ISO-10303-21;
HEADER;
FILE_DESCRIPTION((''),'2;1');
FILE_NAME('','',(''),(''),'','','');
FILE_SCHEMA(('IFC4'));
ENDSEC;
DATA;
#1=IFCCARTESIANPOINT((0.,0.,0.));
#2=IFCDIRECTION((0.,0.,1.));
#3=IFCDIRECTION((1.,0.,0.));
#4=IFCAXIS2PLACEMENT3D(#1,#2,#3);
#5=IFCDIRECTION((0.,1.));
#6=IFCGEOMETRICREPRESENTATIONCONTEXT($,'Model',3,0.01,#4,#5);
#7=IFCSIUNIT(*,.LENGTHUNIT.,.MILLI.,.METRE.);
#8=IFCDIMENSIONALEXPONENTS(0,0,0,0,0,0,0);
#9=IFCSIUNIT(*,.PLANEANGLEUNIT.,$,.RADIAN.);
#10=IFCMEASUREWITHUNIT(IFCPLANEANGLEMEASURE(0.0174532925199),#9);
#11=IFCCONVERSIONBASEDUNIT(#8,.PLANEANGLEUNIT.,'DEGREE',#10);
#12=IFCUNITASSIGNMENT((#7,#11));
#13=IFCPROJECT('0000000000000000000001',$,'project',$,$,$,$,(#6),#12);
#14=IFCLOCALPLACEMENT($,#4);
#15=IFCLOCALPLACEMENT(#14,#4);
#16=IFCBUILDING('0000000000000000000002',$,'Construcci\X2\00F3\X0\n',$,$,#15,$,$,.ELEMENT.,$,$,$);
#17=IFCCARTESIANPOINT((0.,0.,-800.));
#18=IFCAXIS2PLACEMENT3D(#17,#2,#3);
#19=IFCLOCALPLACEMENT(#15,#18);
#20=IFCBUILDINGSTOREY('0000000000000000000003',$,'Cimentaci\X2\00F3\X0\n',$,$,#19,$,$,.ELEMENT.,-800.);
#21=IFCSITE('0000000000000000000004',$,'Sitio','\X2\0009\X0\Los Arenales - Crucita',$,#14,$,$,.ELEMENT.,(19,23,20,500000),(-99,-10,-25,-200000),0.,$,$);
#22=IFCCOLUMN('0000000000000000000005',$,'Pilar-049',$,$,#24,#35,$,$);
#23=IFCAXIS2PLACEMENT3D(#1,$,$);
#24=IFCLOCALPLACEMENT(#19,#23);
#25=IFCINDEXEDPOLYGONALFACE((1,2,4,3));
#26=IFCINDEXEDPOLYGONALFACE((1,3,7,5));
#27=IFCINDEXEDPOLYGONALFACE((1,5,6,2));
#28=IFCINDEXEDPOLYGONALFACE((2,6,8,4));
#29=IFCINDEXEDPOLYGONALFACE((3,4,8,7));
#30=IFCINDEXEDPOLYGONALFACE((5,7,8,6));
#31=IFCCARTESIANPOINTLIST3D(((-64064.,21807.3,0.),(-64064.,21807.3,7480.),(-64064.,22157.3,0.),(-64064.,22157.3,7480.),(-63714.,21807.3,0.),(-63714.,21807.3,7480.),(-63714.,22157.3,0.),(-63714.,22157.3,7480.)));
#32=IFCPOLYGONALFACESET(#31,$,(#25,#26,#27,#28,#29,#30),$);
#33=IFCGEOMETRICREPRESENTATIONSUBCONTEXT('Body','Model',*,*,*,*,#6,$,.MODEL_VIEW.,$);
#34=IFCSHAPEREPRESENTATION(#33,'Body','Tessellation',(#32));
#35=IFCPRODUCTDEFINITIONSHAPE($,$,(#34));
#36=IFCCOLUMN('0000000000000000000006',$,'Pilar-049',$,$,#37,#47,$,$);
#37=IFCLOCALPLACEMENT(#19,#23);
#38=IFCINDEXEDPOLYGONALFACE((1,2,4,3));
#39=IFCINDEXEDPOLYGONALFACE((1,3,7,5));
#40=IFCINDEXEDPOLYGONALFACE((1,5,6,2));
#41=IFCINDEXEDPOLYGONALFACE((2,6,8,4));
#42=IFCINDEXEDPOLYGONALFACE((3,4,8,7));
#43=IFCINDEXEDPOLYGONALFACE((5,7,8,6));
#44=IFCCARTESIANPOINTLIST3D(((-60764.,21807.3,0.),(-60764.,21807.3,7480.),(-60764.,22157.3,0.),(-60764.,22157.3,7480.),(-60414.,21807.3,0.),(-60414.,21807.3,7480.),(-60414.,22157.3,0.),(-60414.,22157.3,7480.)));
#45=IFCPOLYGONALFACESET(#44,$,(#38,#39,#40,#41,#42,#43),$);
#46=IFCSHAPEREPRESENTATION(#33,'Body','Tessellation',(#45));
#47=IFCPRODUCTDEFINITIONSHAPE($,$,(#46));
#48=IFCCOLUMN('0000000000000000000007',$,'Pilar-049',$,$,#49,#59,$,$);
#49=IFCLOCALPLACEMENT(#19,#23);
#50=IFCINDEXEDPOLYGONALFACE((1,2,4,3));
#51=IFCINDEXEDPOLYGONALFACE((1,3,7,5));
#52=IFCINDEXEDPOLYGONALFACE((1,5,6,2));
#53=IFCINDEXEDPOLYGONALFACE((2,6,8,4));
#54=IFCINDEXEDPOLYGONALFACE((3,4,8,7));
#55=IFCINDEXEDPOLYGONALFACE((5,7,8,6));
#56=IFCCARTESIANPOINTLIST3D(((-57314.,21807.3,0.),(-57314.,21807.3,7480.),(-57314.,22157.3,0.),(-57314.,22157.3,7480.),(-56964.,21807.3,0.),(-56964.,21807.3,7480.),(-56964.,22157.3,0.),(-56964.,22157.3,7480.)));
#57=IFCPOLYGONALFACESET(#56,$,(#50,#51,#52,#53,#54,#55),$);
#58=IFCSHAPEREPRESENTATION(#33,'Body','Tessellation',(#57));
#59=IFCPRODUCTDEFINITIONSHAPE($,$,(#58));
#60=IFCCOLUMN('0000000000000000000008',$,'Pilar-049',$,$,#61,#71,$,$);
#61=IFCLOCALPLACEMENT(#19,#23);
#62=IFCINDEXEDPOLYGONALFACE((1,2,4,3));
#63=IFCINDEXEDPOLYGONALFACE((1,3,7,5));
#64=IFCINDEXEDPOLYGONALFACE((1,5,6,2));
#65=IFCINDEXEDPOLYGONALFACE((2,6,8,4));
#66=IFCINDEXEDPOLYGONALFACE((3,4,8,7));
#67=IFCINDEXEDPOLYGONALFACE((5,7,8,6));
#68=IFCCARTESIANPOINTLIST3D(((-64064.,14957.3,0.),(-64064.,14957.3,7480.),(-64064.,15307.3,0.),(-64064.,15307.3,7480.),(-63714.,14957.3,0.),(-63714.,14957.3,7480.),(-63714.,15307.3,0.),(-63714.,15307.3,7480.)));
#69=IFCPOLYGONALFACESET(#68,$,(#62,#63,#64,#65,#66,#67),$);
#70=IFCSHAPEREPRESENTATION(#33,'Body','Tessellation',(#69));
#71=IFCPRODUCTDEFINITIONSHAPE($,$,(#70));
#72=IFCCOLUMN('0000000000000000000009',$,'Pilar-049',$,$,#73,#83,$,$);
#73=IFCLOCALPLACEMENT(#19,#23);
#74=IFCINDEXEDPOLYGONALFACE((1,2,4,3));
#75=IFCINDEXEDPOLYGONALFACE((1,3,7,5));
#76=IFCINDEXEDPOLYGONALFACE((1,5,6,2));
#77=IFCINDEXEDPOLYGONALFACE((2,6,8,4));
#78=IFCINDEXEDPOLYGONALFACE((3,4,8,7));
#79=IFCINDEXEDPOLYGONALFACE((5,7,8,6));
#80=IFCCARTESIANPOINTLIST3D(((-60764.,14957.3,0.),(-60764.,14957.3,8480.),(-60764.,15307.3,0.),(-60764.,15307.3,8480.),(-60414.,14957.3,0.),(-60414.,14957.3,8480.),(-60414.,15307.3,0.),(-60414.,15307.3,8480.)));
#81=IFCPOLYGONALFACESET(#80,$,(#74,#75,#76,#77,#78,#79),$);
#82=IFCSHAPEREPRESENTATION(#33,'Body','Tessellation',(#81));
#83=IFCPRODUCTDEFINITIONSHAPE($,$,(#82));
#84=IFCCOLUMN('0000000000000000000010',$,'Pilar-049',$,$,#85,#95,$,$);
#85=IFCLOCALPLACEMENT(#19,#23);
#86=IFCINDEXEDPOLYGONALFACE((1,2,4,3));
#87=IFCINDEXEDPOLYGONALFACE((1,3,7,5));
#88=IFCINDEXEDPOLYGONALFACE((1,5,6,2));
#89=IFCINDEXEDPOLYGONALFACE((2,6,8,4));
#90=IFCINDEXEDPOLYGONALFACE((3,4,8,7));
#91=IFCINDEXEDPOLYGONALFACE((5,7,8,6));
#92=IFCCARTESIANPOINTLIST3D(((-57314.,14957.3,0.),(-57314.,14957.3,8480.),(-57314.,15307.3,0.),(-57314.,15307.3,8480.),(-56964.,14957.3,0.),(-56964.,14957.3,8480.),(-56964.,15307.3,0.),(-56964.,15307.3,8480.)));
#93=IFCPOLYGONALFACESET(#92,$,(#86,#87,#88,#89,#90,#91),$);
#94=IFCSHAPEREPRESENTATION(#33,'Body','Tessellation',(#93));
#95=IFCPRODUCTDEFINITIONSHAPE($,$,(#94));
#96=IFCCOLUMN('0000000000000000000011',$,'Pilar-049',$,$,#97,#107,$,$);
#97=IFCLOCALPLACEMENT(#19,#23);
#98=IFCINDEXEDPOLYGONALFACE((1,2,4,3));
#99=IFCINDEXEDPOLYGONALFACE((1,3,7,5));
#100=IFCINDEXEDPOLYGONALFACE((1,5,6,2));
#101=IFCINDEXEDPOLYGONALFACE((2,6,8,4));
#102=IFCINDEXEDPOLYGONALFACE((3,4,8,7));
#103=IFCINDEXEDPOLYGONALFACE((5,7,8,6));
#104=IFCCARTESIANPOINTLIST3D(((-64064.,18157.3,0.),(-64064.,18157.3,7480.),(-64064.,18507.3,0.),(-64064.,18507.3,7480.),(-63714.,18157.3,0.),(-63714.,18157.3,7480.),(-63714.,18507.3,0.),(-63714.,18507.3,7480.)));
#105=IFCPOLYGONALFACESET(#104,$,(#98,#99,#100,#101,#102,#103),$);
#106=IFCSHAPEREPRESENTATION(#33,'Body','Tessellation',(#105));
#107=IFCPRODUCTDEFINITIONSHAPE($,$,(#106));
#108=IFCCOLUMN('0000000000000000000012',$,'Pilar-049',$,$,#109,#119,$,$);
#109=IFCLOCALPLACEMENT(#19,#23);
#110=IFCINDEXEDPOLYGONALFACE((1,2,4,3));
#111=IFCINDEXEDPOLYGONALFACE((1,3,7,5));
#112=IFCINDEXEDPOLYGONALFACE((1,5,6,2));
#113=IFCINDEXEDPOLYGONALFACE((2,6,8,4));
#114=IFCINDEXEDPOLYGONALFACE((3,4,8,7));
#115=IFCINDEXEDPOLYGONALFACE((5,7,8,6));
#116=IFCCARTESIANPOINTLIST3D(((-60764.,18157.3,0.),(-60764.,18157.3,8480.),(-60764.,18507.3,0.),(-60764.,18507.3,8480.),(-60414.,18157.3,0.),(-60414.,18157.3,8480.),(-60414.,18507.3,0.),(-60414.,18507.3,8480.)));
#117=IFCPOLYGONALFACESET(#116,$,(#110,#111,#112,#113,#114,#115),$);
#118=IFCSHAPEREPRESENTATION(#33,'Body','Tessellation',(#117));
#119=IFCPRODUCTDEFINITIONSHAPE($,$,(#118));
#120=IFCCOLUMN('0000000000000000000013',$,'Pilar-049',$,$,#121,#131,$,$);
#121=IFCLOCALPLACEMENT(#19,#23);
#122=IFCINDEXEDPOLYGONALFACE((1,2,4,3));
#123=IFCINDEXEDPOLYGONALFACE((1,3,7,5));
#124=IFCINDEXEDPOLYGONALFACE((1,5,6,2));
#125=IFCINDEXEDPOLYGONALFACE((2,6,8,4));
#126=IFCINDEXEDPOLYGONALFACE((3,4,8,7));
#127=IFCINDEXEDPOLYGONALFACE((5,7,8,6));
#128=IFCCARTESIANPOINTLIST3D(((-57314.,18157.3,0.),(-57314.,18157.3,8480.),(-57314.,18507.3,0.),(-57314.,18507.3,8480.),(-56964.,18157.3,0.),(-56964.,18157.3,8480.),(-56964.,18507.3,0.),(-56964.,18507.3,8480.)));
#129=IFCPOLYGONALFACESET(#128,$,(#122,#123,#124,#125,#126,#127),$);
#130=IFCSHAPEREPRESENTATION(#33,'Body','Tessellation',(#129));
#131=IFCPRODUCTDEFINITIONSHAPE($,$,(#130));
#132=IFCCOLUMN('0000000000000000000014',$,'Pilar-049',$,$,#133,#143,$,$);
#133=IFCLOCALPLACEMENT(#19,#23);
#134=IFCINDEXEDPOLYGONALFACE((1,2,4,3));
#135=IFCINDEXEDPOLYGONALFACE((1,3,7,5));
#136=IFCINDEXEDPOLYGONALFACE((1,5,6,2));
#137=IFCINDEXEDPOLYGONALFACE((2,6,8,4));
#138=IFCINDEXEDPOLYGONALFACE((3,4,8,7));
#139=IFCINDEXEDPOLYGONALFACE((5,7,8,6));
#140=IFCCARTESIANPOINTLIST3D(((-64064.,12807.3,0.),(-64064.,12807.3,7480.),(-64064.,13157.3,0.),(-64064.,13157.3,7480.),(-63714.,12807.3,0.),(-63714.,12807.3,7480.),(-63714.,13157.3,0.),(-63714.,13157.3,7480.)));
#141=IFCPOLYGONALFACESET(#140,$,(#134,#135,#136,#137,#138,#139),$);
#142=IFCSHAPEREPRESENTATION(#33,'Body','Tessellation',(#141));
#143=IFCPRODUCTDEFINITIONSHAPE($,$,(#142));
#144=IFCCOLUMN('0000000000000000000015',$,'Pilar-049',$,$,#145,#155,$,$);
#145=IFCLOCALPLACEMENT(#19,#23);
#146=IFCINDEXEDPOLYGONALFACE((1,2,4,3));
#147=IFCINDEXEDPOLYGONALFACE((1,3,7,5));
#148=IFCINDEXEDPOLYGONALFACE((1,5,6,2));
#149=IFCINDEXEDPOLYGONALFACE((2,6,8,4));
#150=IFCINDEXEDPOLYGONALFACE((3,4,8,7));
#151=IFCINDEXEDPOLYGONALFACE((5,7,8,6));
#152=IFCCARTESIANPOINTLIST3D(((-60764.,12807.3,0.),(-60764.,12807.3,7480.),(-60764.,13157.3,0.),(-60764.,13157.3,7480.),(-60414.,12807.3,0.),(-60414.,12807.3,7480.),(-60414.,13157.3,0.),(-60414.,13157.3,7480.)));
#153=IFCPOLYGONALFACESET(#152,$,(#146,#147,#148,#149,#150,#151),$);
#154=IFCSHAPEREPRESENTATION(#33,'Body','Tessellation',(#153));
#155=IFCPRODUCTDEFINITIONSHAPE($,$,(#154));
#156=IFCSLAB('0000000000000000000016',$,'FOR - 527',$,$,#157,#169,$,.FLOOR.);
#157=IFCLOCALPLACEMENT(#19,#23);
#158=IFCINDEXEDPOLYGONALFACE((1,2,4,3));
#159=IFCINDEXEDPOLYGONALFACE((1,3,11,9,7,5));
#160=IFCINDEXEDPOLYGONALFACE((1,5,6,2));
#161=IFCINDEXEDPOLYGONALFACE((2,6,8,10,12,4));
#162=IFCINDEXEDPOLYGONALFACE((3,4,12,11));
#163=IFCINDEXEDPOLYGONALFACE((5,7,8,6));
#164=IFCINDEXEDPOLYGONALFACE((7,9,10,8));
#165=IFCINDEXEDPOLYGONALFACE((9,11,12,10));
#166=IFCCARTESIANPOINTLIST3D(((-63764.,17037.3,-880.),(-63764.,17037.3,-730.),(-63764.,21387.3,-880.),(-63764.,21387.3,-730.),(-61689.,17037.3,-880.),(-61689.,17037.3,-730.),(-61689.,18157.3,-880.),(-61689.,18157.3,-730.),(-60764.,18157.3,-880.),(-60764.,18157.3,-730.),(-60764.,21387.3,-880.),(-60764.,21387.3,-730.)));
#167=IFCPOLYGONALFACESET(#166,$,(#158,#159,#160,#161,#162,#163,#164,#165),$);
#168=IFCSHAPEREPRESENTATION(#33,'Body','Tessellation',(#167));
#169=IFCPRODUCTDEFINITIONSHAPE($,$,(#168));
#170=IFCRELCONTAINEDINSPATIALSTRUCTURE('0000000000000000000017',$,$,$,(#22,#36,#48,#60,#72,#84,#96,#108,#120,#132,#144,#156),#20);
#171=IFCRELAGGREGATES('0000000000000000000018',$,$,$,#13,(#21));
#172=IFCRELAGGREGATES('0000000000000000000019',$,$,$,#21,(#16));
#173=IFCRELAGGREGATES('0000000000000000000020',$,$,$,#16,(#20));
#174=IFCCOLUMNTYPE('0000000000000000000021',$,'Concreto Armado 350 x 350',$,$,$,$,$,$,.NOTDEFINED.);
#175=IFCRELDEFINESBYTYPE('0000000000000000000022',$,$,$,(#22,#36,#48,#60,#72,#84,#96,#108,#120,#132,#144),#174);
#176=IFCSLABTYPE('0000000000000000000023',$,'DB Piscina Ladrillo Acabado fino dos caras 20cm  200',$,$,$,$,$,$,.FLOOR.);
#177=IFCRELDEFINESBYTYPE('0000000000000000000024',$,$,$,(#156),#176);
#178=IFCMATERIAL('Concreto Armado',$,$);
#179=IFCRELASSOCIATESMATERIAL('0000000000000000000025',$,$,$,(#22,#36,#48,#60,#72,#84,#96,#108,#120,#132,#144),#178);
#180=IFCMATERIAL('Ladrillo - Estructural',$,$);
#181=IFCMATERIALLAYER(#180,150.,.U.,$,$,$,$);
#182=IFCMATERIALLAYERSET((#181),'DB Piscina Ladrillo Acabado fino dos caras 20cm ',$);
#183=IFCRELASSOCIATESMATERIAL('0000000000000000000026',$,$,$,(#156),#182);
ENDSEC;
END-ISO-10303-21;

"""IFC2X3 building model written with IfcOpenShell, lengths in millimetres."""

from ifc_helpers import new_model, entity, si_unit, converted_unit, direction, frame, origin_with_axes, origin_2d_with_axis, place, context, subcontext, project, spatial, polyline, rectangle, outline, extrude, material, layer, layer_set, layer_usage, type_object, element, save


model = new_model("IFC2X3")

# Units and contexts
model_context = context("Model", 3, precision=0.01, world=origin_with_axes(), true_north=direction((0.0, 1.0)))
body_context = subcontext(model_context, "Body", "Model", "MODEL_VIEW")
ifc_project = project(units=[si_unit("LENGTHUNIT", "METRE", prefix="MILLI"), converted_unit("PLANEANGLEUNIT", "DEGREE", entity("IfcPlaneAngleMeasure", 0.0174532925199), si_unit("PLANEANGLEUNIT", "RADIAN"), dimensions=[0, 0, 0, 0, 0, 0, 0])], contexts=[model_context])

# Site, building, storey
site_placement = place(None, origin_with_axes())
site = spatial("IfcSite", under=ifc_project, at=site_placement, Name="Sitio", Description="\tLos Arenales - Crucita", CompositionType="ELEMENT", RefLatitude=(19, 23, 20, 500000), RefLongitude=(-99, -10, -25, -200000), RefElevation=0.0)
building_placement = place(site_placement, origin_with_axes())
building = spatial("IfcBuilding", under=site, at=building_placement, Name="Construcción", CompositionType="ELEMENT")
storey_placement = place(building_placement, frame((0.0, 0.0, -800.0), z_axis=(0.0, 0.0, 1.0), x_axis=(1.0, 0.0, 0.0)))
storey = spatial("IfcBuildingStorey", under=building, at=storey_placement, Name="Cimentación", CompositionType="ELEMENT", Elevation=-800.0)

# Columns
ifc_material_1 = material(Name="Concreto Armado")
column_type = type_object("IfcColumnType", Name="Concreto Armado 350 x 350", PredefinedType="NOTDEFINED")
for number, where, z_axis, x_axis, name in (
    (1, (-63889.0, 21982.3, 0.0), (0.0, 0.0, 1.0), (1.0, 0.0, 0.0), "Pilar-049"),
    (2, (-60589.0, 21982.3, 0.0), (0.0, 0.0, 1.0), (1.0, 0.0, 0.0), "Pilar-049"),
    (3, (-57139.0, 21982.3, 0.0), (0.0, 0.0, 1.0), (1.0, 0.0, 0.0), "Pilar-049"),
    (4, (-63889.0, 15132.3, 0.0), (0.0, 0.0, 1.0), (1.0, 0.0, 0.0), "Pilar-049"),
):
    element("IfcColumn", number, at=place(storey_placement, frame(where, z_axis=z_axis, x_axis=x_axis)), inside=storey, type_object=column_type, material=ifc_material_1, Name=name, context=body_context, shape_type="SweptSolid", body=[
        extrude(rectangle(XDim=350.0, YDim=350.0, at=origin_2d_with_axis()), origin_with_axes(), (0.0, 0.0, 1.0), 7480.0),
    ])
for number, where, z_axis, x_axis, name in (
    (5, (-60589.0, 15132.3, 0.0), (0.0, 0.0, 1.0), (1.0, 0.0, 0.0), "Pilar-049"),
    (6, (-57139.0, 15132.3, 0.0), (0.0, 0.0, 1.0), (1.0, 0.0, 0.0), "Pilar-049"),
):
    element("IfcColumn", number, at=place(storey_placement, frame(where, z_axis=z_axis, x_axis=x_axis)), inside=storey, type_object=column_type, material=ifc_material_1, Name=name, context=body_context, shape_type="SweptSolid", body=[
        extrude(rectangle(XDim=350.0, YDim=350.0, at=origin_2d_with_axis()), origin_with_axes(), (0.0, 0.0, 1.0), 8480.0),
    ])
column_placement = place(storey_placement, frame((-63889.0, 18332.3, 0.0), z_axis=(0.0, 0.0, 1.0), x_axis=(1.0, 0.0, 0.0)))
element("IfcColumn", 7, at=column_placement, inside=storey, type_object=column_type, material=ifc_material_1, Name="Pilar-049", context=body_context, shape_type="SweptSolid", body=[
    extrude(rectangle(XDim=350.0, YDim=350.0, at=origin_2d_with_axis()), origin_with_axes(), (0.0, 0.0, 1.0), 7480.0),
])
for number, where, z_axis, x_axis, name in (
    (8, (-60589.0, 18332.3, 0.0), (0.0, 0.0, 1.0), (1.0, 0.0, 0.0), "Pilar-049"),
    (9, (-57139.0, 18332.3, 0.0), (0.0, 0.0, 1.0), (1.0, 0.0, 0.0), "Pilar-049"),
):
    element("IfcColumn", number, at=place(storey_placement, frame(where, z_axis=z_axis, x_axis=x_axis)), inside=storey, type_object=column_type, material=ifc_material_1, Name=name, context=body_context, shape_type="SweptSolid", body=[
        extrude(rectangle(XDim=350.0, YDim=350.0, at=origin_2d_with_axis()), origin_with_axes(), (0.0, 0.0, 1.0), 8480.0),
    ])
for number, where, z_axis, x_axis, name in (
    (10, (-63889.0, 12982.3, 0.0), (0.0, 0.0, 1.0), (1.0, 0.0, 0.0), "Pilar-049"),
    (11, (-60589.0, 12982.3, 0.0), (0.0, 0.0, 1.0), (1.0, 0.0, 0.0), "Pilar-049"),
):
    element("IfcColumn", number, at=place(storey_placement, frame(where, z_axis=z_axis, x_axis=x_axis)), inside=storey, type_object=column_type, material=ifc_material_1, Name=name, context=body_context, shape_type="SweptSolid", body=[
        extrude(rectangle(XDim=350.0, YDim=350.0, at=origin_2d_with_axis()), origin_with_axes(), (0.0, 0.0, 1.0), 7480.0),
    ])

# Slab
ifc_material_2 = material(Name="Ladrillo - Estructural")
ifc_layer = layer(ifc_material_2, 150.0, ventilated="UNKNOWN")
ifc_layer_set = layer_set([ifc_layer], Name="DB Piscina Ladrillo Acabado fino dos caras 20cm ")
ifc_layer_usage = layer_usage(ifc_layer_set, "AXIS3", "NEGATIVE", 150.0)
slab_type = type_object("IfcSlabType", Name="DB Piscina Ladrillo Acabado fino dos caras 20cm  200", PredefinedType="FLOOR")
slab_placement = place(storey_placement, frame((-63764.0, 17037.3, -700.0), z_axis=(0.0, 0.0, 1.0), x_axis=(1.0, 0.0, 0.0)))
element("IfcSlab", 12, at=slab_placement, inside=storey, type_object=slab_type, material=ifc_layer_usage, Name="FOR - 527", PredefinedType="FLOOR", context=body_context, shape_type="SweptSolid", body=[
    extrude(outline(polyline([(0.0, 0.0), (2075.0, 0.0), (2075.0, 1120.0), (3000.0, 1120.0), (3000.0, 4350.0), (0.0, 4350.0), (0.0, 0.0)])), frame((0.0, 0.0, -180.0), z_axis=(0.0, 0.0, 1.0), x_axis=(1.0, 0.0, 0.0)), (0.0, 0.0, 1.0), 150.0),
])

save(model, "model.ifc")
